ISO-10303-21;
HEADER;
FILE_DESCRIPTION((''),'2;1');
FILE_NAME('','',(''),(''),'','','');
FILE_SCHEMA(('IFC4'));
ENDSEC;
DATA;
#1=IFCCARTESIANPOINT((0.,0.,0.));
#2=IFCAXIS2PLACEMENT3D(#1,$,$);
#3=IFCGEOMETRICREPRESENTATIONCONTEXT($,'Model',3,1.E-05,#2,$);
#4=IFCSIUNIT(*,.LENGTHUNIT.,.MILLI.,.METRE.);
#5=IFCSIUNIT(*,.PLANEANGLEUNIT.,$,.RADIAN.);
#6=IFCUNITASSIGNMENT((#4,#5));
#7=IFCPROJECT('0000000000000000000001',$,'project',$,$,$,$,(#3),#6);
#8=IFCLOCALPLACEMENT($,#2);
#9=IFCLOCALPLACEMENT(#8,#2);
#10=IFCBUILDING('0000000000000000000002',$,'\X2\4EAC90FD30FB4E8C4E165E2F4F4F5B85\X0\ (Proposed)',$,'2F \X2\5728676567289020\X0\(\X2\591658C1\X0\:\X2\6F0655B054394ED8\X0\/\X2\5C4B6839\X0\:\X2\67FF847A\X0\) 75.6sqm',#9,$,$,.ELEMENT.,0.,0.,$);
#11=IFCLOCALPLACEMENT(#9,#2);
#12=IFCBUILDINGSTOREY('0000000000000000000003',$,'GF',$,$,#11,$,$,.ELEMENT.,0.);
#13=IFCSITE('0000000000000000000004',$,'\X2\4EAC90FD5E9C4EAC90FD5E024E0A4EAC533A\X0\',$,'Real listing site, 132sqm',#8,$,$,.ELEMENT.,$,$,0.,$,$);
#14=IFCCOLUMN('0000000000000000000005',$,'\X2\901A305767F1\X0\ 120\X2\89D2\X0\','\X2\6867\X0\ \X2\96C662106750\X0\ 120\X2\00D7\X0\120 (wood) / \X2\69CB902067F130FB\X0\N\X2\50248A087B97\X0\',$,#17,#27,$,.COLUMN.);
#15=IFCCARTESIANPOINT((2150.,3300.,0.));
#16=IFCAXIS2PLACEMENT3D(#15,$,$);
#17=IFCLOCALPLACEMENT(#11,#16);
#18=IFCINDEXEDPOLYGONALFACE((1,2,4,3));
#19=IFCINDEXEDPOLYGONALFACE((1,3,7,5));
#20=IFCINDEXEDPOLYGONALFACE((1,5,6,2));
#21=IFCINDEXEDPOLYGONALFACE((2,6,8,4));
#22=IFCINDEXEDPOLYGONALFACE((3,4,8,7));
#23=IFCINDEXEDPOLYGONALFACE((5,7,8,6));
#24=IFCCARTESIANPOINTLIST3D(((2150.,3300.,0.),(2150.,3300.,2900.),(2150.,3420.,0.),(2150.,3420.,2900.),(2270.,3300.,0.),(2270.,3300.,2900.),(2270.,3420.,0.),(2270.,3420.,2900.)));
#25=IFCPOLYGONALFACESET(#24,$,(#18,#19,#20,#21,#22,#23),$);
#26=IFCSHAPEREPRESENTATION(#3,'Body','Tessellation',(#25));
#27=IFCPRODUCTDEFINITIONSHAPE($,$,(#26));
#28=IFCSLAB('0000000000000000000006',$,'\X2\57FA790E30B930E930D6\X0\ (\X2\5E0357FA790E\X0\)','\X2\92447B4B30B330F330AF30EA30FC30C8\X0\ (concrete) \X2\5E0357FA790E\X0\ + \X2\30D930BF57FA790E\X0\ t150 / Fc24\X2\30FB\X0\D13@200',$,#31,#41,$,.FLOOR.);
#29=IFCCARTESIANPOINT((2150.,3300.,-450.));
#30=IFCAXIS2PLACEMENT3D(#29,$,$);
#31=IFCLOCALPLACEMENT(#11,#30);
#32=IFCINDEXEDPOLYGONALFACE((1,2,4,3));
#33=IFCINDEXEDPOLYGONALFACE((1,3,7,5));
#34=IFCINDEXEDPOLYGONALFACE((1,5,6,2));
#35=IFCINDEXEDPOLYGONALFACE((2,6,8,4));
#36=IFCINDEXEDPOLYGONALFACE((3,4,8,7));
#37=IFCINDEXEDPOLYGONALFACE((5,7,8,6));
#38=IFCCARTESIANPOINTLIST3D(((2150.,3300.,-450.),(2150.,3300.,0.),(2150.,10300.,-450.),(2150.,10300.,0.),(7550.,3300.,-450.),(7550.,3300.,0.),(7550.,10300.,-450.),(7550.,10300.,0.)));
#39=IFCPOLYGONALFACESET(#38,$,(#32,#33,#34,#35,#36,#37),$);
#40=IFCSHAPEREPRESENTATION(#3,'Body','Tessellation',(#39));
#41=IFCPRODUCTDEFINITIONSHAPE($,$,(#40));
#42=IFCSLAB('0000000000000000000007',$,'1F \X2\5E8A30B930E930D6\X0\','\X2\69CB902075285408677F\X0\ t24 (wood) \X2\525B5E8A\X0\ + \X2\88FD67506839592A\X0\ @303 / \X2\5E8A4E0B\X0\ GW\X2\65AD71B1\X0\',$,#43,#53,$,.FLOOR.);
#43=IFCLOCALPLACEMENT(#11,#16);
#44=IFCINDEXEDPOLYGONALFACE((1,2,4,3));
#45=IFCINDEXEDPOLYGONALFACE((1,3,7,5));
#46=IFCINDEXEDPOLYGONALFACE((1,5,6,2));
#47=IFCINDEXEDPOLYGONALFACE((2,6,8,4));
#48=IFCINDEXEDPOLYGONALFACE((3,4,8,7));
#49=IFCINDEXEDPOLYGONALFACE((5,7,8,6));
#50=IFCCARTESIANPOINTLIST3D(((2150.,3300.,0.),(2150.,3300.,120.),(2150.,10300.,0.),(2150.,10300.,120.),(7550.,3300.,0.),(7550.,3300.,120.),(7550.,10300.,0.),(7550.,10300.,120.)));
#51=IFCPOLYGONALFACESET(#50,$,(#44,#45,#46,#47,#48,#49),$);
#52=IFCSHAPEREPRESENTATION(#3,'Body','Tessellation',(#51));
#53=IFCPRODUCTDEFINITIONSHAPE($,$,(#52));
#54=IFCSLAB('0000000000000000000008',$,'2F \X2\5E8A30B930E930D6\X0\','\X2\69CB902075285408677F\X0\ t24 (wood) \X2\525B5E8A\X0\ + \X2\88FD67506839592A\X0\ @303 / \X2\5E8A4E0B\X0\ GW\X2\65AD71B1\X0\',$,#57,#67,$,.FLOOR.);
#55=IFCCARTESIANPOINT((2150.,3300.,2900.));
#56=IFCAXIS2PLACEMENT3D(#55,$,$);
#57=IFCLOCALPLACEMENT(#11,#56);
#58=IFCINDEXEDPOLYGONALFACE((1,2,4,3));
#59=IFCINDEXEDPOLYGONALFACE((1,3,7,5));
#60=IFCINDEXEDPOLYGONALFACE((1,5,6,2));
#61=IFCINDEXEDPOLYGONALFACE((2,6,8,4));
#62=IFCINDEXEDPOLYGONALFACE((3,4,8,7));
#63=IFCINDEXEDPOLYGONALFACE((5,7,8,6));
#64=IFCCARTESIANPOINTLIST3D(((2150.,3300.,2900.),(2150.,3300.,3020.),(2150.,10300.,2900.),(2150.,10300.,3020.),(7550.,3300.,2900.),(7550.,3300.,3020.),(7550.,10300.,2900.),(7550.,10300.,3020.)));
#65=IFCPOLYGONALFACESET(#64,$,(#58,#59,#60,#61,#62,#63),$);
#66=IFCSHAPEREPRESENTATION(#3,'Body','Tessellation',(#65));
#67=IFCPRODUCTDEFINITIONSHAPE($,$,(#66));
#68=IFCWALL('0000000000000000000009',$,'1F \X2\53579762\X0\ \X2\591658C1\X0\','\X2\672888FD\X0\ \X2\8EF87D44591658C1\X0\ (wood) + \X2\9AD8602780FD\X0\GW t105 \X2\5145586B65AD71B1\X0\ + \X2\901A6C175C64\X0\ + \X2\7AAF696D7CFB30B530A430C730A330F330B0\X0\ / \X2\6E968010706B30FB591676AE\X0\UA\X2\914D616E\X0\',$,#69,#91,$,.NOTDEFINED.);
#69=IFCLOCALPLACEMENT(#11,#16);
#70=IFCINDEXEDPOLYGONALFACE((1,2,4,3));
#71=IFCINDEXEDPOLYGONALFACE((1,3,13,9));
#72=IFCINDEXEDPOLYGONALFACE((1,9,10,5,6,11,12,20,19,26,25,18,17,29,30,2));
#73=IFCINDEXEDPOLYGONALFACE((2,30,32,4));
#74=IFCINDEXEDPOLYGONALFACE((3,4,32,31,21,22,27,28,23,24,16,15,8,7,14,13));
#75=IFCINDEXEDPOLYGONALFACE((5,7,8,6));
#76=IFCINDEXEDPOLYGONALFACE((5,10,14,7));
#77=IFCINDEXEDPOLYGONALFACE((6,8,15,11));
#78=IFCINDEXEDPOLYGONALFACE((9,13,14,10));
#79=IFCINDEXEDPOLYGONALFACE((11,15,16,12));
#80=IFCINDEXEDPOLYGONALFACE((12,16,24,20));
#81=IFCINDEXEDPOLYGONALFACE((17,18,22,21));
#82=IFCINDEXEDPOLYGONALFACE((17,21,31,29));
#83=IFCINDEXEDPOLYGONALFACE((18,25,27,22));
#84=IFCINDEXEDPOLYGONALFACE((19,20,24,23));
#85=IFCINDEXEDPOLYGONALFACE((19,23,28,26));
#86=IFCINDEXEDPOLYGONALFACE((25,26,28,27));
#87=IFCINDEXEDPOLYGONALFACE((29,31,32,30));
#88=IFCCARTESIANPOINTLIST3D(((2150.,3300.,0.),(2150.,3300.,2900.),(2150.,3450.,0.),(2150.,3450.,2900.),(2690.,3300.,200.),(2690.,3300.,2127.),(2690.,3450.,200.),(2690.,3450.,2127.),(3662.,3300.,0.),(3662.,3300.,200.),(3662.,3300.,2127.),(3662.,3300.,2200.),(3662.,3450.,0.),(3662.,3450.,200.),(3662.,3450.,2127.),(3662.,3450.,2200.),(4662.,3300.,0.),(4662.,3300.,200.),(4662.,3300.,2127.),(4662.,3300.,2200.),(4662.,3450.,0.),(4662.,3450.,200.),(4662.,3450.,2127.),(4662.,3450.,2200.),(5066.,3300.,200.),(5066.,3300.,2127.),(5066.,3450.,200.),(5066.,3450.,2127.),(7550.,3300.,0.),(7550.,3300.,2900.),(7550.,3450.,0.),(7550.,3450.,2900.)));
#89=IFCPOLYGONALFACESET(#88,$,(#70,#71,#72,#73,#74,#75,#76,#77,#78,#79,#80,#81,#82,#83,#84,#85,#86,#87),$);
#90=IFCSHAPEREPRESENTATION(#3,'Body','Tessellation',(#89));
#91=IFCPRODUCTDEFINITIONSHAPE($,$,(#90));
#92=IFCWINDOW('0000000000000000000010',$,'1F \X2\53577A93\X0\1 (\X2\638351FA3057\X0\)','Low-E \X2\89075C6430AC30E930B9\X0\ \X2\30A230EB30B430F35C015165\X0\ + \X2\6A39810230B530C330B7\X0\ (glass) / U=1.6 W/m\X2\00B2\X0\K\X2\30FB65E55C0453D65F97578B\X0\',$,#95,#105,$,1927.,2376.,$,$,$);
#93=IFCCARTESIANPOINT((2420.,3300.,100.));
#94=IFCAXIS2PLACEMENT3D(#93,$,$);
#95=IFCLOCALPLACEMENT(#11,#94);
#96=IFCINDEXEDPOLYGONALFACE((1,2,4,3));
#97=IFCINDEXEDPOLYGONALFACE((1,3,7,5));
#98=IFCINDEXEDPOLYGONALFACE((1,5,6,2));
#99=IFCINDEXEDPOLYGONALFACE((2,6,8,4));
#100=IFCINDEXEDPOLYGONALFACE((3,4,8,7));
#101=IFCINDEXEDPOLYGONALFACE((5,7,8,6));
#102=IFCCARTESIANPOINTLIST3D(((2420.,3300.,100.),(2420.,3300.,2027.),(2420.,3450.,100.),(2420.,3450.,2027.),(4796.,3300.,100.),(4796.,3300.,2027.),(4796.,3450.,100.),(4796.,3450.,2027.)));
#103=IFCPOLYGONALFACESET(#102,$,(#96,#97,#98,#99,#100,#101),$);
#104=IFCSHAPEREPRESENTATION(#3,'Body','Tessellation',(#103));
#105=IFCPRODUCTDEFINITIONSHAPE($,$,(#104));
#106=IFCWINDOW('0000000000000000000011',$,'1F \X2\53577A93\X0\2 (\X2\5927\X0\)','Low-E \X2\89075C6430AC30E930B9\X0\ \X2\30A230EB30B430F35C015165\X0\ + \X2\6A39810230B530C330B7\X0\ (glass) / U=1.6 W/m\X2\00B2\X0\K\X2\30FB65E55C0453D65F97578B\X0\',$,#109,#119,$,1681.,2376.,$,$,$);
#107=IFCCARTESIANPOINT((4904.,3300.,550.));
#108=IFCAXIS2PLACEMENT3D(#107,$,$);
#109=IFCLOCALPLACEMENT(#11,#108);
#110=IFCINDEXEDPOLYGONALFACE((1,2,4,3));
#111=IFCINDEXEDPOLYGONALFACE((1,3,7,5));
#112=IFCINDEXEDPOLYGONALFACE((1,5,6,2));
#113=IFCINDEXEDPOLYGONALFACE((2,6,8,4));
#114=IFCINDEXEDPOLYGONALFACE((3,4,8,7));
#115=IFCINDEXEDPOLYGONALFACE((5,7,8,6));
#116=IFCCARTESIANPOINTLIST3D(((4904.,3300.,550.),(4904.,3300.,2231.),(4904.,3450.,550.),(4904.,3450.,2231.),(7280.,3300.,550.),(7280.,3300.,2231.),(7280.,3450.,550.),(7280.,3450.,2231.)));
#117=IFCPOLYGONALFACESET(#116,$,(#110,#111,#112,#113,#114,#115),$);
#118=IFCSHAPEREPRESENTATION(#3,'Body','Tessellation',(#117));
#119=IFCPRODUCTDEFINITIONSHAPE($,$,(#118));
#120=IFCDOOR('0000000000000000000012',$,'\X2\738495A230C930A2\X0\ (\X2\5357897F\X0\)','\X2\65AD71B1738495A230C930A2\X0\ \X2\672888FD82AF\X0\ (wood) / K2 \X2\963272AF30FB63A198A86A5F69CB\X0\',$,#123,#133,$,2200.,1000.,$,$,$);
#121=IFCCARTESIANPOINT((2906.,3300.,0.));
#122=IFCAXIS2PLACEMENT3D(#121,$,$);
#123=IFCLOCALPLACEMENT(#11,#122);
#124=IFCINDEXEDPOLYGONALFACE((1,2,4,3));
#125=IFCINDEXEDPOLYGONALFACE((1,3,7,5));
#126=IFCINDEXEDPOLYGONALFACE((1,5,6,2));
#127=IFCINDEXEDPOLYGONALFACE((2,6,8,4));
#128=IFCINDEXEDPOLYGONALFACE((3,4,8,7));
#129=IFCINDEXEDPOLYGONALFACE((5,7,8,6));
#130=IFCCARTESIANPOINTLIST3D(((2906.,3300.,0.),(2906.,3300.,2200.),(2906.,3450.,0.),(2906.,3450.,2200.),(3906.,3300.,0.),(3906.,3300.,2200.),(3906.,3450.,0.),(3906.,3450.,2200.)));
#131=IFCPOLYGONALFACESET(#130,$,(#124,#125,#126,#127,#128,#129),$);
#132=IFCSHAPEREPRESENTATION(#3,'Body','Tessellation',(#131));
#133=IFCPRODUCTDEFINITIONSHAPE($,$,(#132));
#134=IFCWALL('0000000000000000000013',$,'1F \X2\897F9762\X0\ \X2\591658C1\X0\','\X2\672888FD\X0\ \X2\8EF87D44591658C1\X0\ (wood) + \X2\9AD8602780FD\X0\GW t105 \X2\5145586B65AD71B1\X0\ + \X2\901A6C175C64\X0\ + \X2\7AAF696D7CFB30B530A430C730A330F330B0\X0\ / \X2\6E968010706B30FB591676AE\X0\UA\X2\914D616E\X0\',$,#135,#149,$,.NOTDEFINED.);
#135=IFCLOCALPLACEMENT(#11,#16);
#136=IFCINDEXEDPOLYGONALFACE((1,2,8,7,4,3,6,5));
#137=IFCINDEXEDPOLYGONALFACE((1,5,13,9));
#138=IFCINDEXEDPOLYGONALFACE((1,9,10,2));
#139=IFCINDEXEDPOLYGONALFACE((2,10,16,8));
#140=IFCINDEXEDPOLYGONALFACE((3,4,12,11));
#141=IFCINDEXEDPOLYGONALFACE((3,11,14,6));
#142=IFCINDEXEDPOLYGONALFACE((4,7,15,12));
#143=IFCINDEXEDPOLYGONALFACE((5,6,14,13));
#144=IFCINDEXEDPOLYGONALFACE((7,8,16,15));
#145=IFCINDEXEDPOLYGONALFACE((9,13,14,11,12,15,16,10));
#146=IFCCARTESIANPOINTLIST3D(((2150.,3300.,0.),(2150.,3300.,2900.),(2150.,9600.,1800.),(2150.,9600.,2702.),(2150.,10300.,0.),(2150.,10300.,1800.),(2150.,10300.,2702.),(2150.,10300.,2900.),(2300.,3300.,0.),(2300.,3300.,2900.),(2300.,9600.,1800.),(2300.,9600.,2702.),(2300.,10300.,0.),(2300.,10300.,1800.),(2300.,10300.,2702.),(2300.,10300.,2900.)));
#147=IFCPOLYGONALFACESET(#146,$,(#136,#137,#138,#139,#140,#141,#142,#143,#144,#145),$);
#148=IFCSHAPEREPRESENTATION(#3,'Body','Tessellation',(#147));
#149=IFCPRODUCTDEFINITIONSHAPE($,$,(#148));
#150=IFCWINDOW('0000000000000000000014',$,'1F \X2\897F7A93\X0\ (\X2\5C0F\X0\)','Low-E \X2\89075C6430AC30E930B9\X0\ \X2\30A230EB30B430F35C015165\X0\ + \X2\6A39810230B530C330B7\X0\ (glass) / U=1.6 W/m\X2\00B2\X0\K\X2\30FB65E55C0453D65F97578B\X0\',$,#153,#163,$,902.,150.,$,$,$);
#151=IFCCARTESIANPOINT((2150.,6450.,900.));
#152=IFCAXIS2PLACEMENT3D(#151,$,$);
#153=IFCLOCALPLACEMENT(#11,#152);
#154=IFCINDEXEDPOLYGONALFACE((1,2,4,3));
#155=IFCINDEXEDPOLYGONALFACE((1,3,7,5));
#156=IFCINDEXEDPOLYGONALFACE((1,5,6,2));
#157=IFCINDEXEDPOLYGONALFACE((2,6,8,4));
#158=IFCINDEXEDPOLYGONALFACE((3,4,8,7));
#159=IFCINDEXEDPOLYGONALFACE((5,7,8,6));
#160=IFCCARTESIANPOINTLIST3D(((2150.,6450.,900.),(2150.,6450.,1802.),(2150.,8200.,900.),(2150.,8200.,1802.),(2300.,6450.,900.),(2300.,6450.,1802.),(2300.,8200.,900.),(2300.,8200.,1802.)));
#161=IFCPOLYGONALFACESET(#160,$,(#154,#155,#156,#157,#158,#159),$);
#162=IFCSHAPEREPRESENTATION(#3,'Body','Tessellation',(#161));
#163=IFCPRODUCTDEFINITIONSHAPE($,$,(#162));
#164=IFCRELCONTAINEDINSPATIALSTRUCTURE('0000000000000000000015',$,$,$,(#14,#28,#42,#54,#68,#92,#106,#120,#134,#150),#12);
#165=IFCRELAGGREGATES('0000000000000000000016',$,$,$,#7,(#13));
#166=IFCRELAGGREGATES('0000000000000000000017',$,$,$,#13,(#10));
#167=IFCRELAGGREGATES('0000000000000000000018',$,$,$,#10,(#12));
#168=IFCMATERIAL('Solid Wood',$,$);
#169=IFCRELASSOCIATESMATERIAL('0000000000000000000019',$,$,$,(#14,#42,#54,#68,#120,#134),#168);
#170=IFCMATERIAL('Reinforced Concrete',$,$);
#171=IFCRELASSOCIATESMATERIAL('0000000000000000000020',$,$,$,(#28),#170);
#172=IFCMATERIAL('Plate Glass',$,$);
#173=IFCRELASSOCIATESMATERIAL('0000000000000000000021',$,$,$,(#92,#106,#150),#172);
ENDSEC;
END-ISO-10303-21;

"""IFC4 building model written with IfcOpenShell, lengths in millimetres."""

from ifc_helpers import new_model, si_unit, frame, frame_2d, origin, place, context, project, spatial, rectangle, extrude, material, element, fill, save


model = new_model("IFC4")

# Units and contexts
model_context = context("Model", 3, precision=1e-05, world=origin())
ifc_project = project(units=[si_unit("LENGTHUNIT", "METRE", prefix="MILLI"), si_unit("PLANEANGLEUNIT", "RADIAN")], contexts=[model_context])

# Site, building, storey
site_placement = place(None, origin())
site = spatial("IfcSite", under=ifc_project, at=site_placement, Name="京都府京都市上京区", ObjectType="Real listing site, 132sqm", CompositionType="ELEMENT", RefElevation=0.0)
building_placement = place(site_placement, origin())
building = spatial("IfcBuilding", under=site, at=building_placement, Name="京都・二世帯住宅 (Proposed)", ObjectType="2F 在来木造(外壁:漆喰吹付/屋根:柿葺) 75.6sqm", CompositionType="ELEMENT", ElevationOfRefHeight=0.0, ElevationOfTerrain=0.0)
storey_placement = place(building_placement, origin())
storey = spatial("IfcBuildingStorey", under=building, at=storey_placement, Name="GF", CompositionType="ELEMENT", Elevation=0.0)

# Column
ifc_material_1 = material(Name="Solid Wood")
column_placement = place(storey_placement, frame((2150.0, 3300.0, 0.0)))
element("IfcColumn", 1, at=column_placement, inside=storey, material=ifc_material_1, Name="通し柱 120角", Description="桧 集成材 120×120 (wood) / 構造柱・N値計算", PredefinedType="COLUMN", context=model_context, shape_type="SweptSolid", body=[
    extrude(rectangle(XDim=120.0, YDim=120.0, at=frame_2d((60.0, 60.0))), frame((2150.0, 3300.0, 0.0)), (0.0, 0.0, 1.0), 2900.0),
])

# Slabs
ifc_material_2 = material(Name="Reinforced Concrete")
slab_1_placement = place(storey_placement, frame((2150.0, 3300.0, -450.0)))
element("IfcSlab", 2, at=slab_1_placement, inside=storey, material=ifc_material_2, Name="基礎スラブ (布基礎)", Description="鉄筋コンクリート (concrete) 布基礎 + ベタ基礎 t150 / Fc24・D13@200", PredefinedType="FLOOR", context=model_context, shape_type="SweptSolid", body=[
    extrude(rectangle(XDim=5400.0, YDim=7000.0, at=frame_2d((2700.0, 3500.0))), frame((2150.0, 3300.0, -450.0)), (0.0, 0.0, 1.0), 450.0),
])
slab_2_placement = place(storey_placement, frame((2150.0, 3300.0, 0.0)))
element("IfcSlab", 3, at=slab_2_placement, inside=storey, material=ifc_material_1, Name="1F 床スラブ", Description="構造用合板 t24 (wood) 剛床 + 製材根太 @303 / 床下 GW断熱", PredefinedType="FLOOR", context=model_context, shape_type="SweptSolid", body=[
    extrude(rectangle(XDim=5400.0, YDim=7000.0, at=frame_2d((2700.0, 3500.0))), frame((2150.0, 3300.0, 0.0)), (0.0, 0.0, 1.0), 120.0),
])
slab_3_placement = place(storey_placement, frame((2150.0, 3300.0, 2900.0)))
element("IfcSlab", 4, at=slab_3_placement, inside=storey, material=ifc_material_1, Name="2F 床スラブ", Description="構造用合板 t24 (wood) 剛床 + 製材根太 @303 / 床下 GW断熱", PredefinedType="FLOOR", context=model_context, shape_type="SweptSolid", body=[
    extrude(rectangle(XDim=5400.0, YDim=7000.0, at=frame_2d((2700.0, 3500.0))), frame((2150.0, 3300.0, 2900.0)), (0.0, 0.0, 1.0), 120.0),
])

# Wall, openings, windows, door
wall_1_placement = place(storey_placement, frame((2150.0, 3300.0, 0.0)))
wall_1 = element("IfcWall", 5, at=wall_1_placement, inside=storey, material=ifc_material_1, Name="1F 南面 外壁", Description="木製 軸組外壁 (wood) + 高性能GW t105 充填断熱 + 通気層 + 窯業系サイディング / 準耐火・外皮UA配慮", PredefinedType="NOTDEFINED", context=model_context, shape_type="SweptSolid", body=[
    extrude(rectangle(XDim=5400.0, YDim=150.0, at=frame_2d((2700.0, 75.0))), frame((2150.0, 3300.0, 0.0)), (0.0, 0.0, 1.0), 2900.0),
])
opening_1_placement = place(storey_placement, frame((2420.0, 3300.0, 100.0)))
opening_1 = element("IfcOpeningElement", 6, at=opening_1_placement, cuts=wall_1, PredefinedType="NOTDEFINED", context=model_context, shape_type="SweptSolid", body=[
    extrude(rectangle(XDim=2376.0, YDim=150.0, at=frame_2d((1188.0, 75.0))), frame((2420.0, 3300.0, 100.0)), (0.0, 0.0, 1.0), 1927.0),
])
opening_2_placement = place(storey_placement, frame((4904.0, 3300.0, 550.0)))
opening_2 = element("IfcOpeningElement", 7, at=opening_2_placement, cuts=wall_1, PredefinedType="NOTDEFINED", context=model_context, shape_type="SweptSolid", body=[
    extrude(rectangle(XDim=2376.0, YDim=150.0, at=frame_2d((1188.0, 75.0))), frame((4904.0, 3300.0, 550.0)), (0.0, 0.0, 1.0), 1681.0),
])
opening_3_placement = place(storey_placement, frame((2906.0, 3300.0, 0.0)))
opening_3 = element("IfcOpeningElement", 8, at=opening_3_placement, cuts=wall_1, PredefinedType="NOTDEFINED", context=model_context, shape_type="SweptSolid", body=[
    extrude(rectangle(XDim=1000.0, YDim=150.0, at=frame_2d((500.0, 75.0))), frame((2906.0, 3300.0, 0.0)), (0.0, 0.0, 1.0), 2200.0),
])
ifc_material_3 = material(Name="Plate Glass")
window_1_placement = place(storey_placement, frame((2420.0, 3300.0, 100.0)))
window_1 = element("IfcWindow", 9, at=window_1_placement, inside=storey, material=ifc_material_3, Name="1F 南窓1 (掃出し)", Description="Low-E 複層ガラス アルゴン封入 + 樹脂サッシ (glass) / U=1.6 W/m²K・日射取得型", OverallHeight=1927.0, OverallWidth=2376.0, context=model_context, shape_type="SweptSolid", body=[
    extrude(rectangle(XDim=2376.0, YDim=150.0, at=frame_2d((1188.0, 75.0))), frame((2420.0, 3300.0, 100.0)), (0.0, 0.0, 1.0), 1927.0),
])
fill(opening_1, window_1)
window_2_placement = place(storey_placement, frame((4904.0, 3300.0, 550.0)))
window_2 = element("IfcWindow", 10, at=window_2_placement, inside=storey, material=ifc_material_3, Name="1F 南窓2 (大)", Description="Low-E 複層ガラス アルゴン封入 + 樹脂サッシ (glass) / U=1.6 W/m²K・日射取得型", OverallHeight=1681.0, OverallWidth=2376.0, context=model_context, shape_type="SweptSolid", body=[
    extrude(rectangle(XDim=2376.0, YDim=150.0, at=frame_2d((1188.0, 75.0))), frame((4904.0, 3300.0, 550.0)), (0.0, 0.0, 1.0), 1681.0),
])
fill(opening_2, window_2)
door_placement = place(storey_placement, frame((2906.0, 3300.0, 0.0)))
door = element("IfcDoor", 11, at=door_placement, inside=storey, material=ifc_material_1, Name="玄関ドア (南西)", Description="断熱玄関ドア 木製芯 (wood) / K2 防犯・採風機構", OverallHeight=2200.0, OverallWidth=1000.0, context=model_context, shape_type="SweptSolid", body=[
    extrude(rectangle(XDim=1000.0, YDim=150.0, at=frame_2d((500.0, 75.0))), frame((2906.0, 3300.0, 0.0)), (0.0, 0.0, 1.0), 2200.0),
])
fill(opening_3, door)

# Wall, opening, window
wall_2_placement = place(storey_placement, frame((2150.0, 3300.0, 0.0)))
wall_2 = element("IfcWall", 12, at=wall_2_placement, inside=storey, material=ifc_material_1, Name="1F 西面 外壁", Description="木製 軸組外壁 (wood) + 高性能GW t105 充填断熱 + 通気層 + 窯業系サイディング / 準耐火・外皮UA配慮", PredefinedType="NOTDEFINED", context=model_context, shape_type="SweptSolid", body=[
    extrude(rectangle(XDim=150.0, YDim=7000.0, at=frame_2d((75.0, 3500.0))), frame((2150.0, 3300.0, 0.0)), (0.0, 0.0, 1.0), 2900.0),
])
opening_4_placement = place(storey_placement, frame((2150.0, 6450.0, 900.0)))
opening_4 = element("IfcOpeningElement", 13, at=opening_4_placement, cuts=wall_2, PredefinedType="NOTDEFINED", context=model_context, shape_type="SweptSolid", body=[
    extrude(rectangle(XDim=150.0, YDim=1750.0, at=frame_2d((75.0, 875.0))), frame((2150.0, 6450.0, 900.0)), (0.0, 0.0, 1.0), 902.0),
])
window_3_placement = place(storey_placement, frame((2150.0, 6450.0, 900.0)))
window_3 = element("IfcWindow", 14, at=window_3_placement, inside=storey, material=ifc_material_3, Name="1F 西窓 (小)", Description="Low-E 複層ガラス アルゴン封入 + 樹脂サッシ (glass) / U=1.6 W/m²K・日射取得型", OverallHeight=902.0, OverallWidth=150.0, context=model_context, shape_type="SweptSolid", body=[
    extrude(rectangle(XDim=150.0, YDim=1750.0, at=frame_2d((75.0, 875.0))), frame((2150.0, 6450.0, 900.0)), (0.0, 0.0, 1.0), 902.0),
])
fill(opening_4, window_3)

save(model, "model.ifc")
